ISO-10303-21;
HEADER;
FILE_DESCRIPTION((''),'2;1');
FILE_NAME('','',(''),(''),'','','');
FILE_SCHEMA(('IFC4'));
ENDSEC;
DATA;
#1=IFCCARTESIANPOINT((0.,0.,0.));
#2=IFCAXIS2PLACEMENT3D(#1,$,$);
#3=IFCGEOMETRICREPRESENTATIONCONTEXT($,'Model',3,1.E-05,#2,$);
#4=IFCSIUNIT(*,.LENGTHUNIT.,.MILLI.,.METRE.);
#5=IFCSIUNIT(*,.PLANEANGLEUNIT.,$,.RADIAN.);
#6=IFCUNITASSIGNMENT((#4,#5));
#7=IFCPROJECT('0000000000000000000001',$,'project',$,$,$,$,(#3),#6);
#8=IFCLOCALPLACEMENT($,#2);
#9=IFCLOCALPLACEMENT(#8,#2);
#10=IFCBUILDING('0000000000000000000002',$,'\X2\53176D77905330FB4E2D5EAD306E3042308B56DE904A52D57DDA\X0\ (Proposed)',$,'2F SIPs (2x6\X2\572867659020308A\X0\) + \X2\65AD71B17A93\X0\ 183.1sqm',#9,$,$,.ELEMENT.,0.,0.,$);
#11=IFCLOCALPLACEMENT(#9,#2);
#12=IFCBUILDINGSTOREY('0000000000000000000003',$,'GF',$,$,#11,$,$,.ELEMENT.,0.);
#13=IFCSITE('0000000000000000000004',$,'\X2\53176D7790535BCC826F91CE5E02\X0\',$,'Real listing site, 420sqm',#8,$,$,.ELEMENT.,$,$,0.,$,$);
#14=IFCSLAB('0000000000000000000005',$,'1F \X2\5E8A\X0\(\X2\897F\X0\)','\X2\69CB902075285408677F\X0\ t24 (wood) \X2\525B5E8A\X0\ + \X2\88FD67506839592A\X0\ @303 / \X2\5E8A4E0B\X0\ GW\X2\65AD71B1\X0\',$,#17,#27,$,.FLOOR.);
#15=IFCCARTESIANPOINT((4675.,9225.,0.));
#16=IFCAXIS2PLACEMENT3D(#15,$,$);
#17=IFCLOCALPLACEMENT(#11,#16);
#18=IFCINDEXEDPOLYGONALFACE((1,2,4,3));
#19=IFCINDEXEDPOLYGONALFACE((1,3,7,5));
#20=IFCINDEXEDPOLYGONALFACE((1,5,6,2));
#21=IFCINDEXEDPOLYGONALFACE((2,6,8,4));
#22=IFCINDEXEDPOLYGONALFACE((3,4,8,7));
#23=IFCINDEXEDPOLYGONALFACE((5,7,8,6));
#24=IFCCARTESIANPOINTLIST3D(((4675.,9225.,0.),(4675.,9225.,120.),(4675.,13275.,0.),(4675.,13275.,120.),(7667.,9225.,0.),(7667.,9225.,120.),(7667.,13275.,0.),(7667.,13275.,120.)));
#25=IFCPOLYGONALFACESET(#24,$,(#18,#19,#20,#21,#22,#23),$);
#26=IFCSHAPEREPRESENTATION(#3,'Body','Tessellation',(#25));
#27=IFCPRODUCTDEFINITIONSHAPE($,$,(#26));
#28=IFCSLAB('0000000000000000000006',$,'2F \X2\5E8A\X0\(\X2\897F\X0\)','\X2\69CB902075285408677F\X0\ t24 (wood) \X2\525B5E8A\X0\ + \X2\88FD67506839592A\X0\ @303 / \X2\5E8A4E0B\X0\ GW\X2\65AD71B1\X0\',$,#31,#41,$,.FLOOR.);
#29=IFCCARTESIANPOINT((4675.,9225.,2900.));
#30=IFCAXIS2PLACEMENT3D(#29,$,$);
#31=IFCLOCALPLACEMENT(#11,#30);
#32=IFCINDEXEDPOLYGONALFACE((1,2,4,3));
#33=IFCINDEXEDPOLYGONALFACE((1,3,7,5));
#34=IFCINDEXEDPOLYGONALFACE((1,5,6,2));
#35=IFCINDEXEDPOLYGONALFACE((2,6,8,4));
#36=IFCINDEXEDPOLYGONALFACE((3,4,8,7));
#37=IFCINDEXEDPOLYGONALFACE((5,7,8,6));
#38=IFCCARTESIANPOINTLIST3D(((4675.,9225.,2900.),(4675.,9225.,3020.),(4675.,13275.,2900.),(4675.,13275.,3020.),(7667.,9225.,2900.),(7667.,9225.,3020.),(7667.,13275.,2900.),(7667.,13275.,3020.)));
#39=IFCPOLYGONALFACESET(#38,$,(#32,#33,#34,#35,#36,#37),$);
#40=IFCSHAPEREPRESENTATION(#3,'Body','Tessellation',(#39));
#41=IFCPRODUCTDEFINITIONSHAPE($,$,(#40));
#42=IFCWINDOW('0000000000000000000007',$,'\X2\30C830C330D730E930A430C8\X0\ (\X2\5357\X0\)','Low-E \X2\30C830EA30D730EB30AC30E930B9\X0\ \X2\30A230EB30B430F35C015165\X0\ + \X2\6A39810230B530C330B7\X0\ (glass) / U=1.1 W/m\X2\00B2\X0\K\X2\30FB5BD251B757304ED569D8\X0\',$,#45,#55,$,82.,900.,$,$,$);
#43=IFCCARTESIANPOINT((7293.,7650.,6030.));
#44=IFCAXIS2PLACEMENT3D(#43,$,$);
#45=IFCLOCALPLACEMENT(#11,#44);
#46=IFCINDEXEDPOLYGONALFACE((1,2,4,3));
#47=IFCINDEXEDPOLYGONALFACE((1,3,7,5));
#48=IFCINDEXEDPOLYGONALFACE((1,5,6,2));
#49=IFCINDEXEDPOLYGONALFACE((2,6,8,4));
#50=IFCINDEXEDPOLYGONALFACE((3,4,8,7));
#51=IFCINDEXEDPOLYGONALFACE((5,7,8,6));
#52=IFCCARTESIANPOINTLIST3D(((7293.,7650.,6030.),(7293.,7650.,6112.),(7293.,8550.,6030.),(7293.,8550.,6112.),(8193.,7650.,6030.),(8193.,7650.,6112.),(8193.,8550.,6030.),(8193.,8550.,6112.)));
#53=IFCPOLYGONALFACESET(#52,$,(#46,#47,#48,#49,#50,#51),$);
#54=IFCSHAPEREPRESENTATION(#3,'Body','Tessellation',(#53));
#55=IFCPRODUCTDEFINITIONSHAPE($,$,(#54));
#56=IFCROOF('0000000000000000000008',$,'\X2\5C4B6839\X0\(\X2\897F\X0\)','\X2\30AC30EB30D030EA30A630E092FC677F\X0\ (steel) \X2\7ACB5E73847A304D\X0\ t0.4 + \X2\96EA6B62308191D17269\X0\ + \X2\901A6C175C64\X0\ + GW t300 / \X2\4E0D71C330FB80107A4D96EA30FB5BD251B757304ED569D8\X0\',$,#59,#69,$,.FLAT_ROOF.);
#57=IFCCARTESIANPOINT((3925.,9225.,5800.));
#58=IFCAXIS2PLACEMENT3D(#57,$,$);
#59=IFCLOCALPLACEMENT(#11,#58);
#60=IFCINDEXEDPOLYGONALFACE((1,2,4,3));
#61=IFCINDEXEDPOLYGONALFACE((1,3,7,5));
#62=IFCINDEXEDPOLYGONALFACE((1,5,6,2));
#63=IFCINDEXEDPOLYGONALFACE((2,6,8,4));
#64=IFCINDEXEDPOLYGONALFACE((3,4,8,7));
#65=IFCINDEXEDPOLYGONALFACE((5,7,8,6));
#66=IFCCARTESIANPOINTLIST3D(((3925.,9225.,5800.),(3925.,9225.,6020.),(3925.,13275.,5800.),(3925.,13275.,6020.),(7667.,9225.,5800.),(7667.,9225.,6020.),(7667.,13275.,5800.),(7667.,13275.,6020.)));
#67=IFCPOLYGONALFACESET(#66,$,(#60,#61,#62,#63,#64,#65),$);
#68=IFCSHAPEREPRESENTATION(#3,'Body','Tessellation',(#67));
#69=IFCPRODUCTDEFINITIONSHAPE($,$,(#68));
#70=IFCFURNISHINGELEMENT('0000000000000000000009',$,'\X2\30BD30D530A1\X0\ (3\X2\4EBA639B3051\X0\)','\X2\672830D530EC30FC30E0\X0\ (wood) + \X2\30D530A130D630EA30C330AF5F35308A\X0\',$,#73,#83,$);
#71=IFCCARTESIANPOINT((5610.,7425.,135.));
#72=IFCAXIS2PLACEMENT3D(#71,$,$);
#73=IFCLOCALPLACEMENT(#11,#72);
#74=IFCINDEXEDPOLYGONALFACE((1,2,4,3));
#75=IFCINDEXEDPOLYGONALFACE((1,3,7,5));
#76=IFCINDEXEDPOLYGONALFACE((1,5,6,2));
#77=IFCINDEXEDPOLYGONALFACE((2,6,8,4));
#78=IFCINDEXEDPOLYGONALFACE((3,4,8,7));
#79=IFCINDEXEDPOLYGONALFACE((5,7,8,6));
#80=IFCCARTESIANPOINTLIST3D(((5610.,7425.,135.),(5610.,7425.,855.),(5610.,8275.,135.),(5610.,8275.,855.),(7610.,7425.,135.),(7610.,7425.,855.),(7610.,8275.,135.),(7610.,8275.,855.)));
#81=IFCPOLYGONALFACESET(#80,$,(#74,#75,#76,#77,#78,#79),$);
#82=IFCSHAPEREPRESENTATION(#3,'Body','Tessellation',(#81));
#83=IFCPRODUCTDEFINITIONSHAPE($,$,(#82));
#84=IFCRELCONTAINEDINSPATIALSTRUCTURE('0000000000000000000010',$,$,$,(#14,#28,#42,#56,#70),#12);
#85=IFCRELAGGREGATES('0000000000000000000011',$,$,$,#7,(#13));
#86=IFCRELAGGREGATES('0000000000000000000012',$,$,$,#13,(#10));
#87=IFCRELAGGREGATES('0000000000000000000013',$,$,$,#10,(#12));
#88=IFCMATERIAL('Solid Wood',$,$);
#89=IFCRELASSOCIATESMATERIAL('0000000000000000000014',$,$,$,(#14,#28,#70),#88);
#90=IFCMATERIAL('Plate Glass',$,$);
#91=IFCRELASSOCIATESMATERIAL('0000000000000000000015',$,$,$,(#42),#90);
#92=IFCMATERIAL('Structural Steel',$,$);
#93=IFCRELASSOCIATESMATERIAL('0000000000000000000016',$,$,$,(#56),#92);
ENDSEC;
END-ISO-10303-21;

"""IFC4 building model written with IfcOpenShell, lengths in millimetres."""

from ifc_helpers import new_model, si_unit, frame, frame_2d, origin, place, context, project, spatial, rectangle, extrude, material, element, save


model = new_model("IFC4")

# Units and contexts
model_context = context("Model", 3, precision=1e-05, world=origin())
ifc_project = project(units=[si_unit("LENGTHUNIT", "METRE", prefix="MILLI"), si_unit("PLANEANGLEUNIT", "RADIAN")], contexts=[model_context])

# Site, building, storey
site_placement = place(None, origin())
site = spatial("IfcSite", under=ifc_project, at=site_placement, Name="北海道富良野市", ObjectType="Real listing site, 420sqm", CompositionType="ELEMENT", RefElevation=0.0)
building_placement = place(site_placement, origin())
building = spatial("IfcBuilding", under=site, at=building_placement, Name="北海道・中庭のある回遊動線 (Proposed)", ObjectType="2F SIPs (2x6在来造り) + 断熱窓 183.1sqm", CompositionType="ELEMENT", ElevationOfRefHeight=0.0, ElevationOfTerrain=0.0)
storey_placement = place(building_placement, origin())
storey = spatial("IfcBuildingStorey", under=building, at=storey_placement, Name="GF", CompositionType="ELEMENT", Elevation=0.0)

# Shared definitions
ifc_material_1 = material(Name="Solid Wood")

# Slabs
slab_1_placement = place(storey_placement, frame((4675.0, 9225.0, 0.0)))
element("IfcSlab", 1, at=slab_1_placement, inside=storey, material=ifc_material_1, Name="1F 床(西)", Description="構造用合板 t24 (wood) 剛床 + 製材根太 @303 / 床下 GW断熱", PredefinedType="FLOOR", context=model_context, shape_type="SweptSolid", body=[
    extrude(rectangle(XDim=2992.0, YDim=4050.0, at=frame_2d((1496.0, 2025.0))), frame((4675.0, 9225.0, 0.0)), (0.0, 0.0, 1.0), 120.0),
])
slab_2_placement = place(storey_placement, frame((4675.0, 9225.0, 2900.0)))
element("IfcSlab", 2, at=slab_2_placement, inside=storey, material=ifc_material_1, Name="2F 床(西)", Description="構造用合板 t24 (wood) 剛床 + 製材根太 @303 / 床下 GW断熱", PredefinedType="FLOOR", context=model_context, shape_type="SweptSolid", body=[
    extrude(rectangle(XDim=2992.0, YDim=4050.0, at=frame_2d((1496.0, 2025.0))), frame((4675.0, 9225.0, 2900.0)), (0.0, 0.0, 1.0), 120.0),
])

# Window
ifc_material_2 = material(Name="Plate Glass")
window_placement = place(storey_placement, frame((7293.0, 7650.0, 6030.0)))
element("IfcWindow", 3, at=window_placement, inside=storey, material=ifc_material_2, Name="トップライト (南)", Description="Low-E トリプルガラス アルゴン封入 + 樹脂サッシ (glass) / U=1.1 W/m²K・寒冷地仕様", OverallHeight=82.0, OverallWidth=900.0, context=model_context, shape_type="SweptSolid", body=[
    extrude(rectangle(XDim=900.0, YDim=900.0, at=frame_2d((450.0, 450.0))), frame((7293.0, 7650.0, 6030.0)), (0.0, 0.0, 1.0), 82.0),
])

# Roof
ifc_material_3 = material(Name="Structural Steel")
for number, where, name in (
    (4, (3925.0, 9225.0, 5800.0), "屋根(西)"),
):
    element("IfcRoof", number, at=place(storey_placement, frame(where)), inside=storey, material=ifc_material_3, Name=name, Description="ガルバリウム鋼板 (steel) 立平葺き t0.4 + 雪止め金物 + 通気層 + GW t300 / 不燃・耐積雪・寒冷地仕様", PredefinedType="FLAT_ROOF", context=model_context, shape_type="SweptSolid", body=[
        extrude(rectangle(XDim=3742.0, YDim=4050.0, at=frame_2d((1871.0, 2025.0))), frame((3925.0, 9225.0, 5800.0)), (0.0, 0.0, 1.0), 220.0),
    ])

# Furnishing element
furnishing_placement = place(storey_placement, frame((5610.0, 7425.0, 135.0)))
element("IfcFurnishingElement", 5, at=furnishing_placement, inside=storey, material=ifc_material_1, Name="ソファ (3人掛け)", Description="木フレーム (wood) + ファブリック張り", context=model_context, shape_type="SweptSolid", body=[
    extrude(rectangle(XDim=2000.0, YDim=850.0, at=frame_2d((1000.0, 425.0))), frame((5610.0, 7425.0, 135.0)), (0.0, 0.0, 1.0), 720.0),
])

save(model, "model.ifc")
